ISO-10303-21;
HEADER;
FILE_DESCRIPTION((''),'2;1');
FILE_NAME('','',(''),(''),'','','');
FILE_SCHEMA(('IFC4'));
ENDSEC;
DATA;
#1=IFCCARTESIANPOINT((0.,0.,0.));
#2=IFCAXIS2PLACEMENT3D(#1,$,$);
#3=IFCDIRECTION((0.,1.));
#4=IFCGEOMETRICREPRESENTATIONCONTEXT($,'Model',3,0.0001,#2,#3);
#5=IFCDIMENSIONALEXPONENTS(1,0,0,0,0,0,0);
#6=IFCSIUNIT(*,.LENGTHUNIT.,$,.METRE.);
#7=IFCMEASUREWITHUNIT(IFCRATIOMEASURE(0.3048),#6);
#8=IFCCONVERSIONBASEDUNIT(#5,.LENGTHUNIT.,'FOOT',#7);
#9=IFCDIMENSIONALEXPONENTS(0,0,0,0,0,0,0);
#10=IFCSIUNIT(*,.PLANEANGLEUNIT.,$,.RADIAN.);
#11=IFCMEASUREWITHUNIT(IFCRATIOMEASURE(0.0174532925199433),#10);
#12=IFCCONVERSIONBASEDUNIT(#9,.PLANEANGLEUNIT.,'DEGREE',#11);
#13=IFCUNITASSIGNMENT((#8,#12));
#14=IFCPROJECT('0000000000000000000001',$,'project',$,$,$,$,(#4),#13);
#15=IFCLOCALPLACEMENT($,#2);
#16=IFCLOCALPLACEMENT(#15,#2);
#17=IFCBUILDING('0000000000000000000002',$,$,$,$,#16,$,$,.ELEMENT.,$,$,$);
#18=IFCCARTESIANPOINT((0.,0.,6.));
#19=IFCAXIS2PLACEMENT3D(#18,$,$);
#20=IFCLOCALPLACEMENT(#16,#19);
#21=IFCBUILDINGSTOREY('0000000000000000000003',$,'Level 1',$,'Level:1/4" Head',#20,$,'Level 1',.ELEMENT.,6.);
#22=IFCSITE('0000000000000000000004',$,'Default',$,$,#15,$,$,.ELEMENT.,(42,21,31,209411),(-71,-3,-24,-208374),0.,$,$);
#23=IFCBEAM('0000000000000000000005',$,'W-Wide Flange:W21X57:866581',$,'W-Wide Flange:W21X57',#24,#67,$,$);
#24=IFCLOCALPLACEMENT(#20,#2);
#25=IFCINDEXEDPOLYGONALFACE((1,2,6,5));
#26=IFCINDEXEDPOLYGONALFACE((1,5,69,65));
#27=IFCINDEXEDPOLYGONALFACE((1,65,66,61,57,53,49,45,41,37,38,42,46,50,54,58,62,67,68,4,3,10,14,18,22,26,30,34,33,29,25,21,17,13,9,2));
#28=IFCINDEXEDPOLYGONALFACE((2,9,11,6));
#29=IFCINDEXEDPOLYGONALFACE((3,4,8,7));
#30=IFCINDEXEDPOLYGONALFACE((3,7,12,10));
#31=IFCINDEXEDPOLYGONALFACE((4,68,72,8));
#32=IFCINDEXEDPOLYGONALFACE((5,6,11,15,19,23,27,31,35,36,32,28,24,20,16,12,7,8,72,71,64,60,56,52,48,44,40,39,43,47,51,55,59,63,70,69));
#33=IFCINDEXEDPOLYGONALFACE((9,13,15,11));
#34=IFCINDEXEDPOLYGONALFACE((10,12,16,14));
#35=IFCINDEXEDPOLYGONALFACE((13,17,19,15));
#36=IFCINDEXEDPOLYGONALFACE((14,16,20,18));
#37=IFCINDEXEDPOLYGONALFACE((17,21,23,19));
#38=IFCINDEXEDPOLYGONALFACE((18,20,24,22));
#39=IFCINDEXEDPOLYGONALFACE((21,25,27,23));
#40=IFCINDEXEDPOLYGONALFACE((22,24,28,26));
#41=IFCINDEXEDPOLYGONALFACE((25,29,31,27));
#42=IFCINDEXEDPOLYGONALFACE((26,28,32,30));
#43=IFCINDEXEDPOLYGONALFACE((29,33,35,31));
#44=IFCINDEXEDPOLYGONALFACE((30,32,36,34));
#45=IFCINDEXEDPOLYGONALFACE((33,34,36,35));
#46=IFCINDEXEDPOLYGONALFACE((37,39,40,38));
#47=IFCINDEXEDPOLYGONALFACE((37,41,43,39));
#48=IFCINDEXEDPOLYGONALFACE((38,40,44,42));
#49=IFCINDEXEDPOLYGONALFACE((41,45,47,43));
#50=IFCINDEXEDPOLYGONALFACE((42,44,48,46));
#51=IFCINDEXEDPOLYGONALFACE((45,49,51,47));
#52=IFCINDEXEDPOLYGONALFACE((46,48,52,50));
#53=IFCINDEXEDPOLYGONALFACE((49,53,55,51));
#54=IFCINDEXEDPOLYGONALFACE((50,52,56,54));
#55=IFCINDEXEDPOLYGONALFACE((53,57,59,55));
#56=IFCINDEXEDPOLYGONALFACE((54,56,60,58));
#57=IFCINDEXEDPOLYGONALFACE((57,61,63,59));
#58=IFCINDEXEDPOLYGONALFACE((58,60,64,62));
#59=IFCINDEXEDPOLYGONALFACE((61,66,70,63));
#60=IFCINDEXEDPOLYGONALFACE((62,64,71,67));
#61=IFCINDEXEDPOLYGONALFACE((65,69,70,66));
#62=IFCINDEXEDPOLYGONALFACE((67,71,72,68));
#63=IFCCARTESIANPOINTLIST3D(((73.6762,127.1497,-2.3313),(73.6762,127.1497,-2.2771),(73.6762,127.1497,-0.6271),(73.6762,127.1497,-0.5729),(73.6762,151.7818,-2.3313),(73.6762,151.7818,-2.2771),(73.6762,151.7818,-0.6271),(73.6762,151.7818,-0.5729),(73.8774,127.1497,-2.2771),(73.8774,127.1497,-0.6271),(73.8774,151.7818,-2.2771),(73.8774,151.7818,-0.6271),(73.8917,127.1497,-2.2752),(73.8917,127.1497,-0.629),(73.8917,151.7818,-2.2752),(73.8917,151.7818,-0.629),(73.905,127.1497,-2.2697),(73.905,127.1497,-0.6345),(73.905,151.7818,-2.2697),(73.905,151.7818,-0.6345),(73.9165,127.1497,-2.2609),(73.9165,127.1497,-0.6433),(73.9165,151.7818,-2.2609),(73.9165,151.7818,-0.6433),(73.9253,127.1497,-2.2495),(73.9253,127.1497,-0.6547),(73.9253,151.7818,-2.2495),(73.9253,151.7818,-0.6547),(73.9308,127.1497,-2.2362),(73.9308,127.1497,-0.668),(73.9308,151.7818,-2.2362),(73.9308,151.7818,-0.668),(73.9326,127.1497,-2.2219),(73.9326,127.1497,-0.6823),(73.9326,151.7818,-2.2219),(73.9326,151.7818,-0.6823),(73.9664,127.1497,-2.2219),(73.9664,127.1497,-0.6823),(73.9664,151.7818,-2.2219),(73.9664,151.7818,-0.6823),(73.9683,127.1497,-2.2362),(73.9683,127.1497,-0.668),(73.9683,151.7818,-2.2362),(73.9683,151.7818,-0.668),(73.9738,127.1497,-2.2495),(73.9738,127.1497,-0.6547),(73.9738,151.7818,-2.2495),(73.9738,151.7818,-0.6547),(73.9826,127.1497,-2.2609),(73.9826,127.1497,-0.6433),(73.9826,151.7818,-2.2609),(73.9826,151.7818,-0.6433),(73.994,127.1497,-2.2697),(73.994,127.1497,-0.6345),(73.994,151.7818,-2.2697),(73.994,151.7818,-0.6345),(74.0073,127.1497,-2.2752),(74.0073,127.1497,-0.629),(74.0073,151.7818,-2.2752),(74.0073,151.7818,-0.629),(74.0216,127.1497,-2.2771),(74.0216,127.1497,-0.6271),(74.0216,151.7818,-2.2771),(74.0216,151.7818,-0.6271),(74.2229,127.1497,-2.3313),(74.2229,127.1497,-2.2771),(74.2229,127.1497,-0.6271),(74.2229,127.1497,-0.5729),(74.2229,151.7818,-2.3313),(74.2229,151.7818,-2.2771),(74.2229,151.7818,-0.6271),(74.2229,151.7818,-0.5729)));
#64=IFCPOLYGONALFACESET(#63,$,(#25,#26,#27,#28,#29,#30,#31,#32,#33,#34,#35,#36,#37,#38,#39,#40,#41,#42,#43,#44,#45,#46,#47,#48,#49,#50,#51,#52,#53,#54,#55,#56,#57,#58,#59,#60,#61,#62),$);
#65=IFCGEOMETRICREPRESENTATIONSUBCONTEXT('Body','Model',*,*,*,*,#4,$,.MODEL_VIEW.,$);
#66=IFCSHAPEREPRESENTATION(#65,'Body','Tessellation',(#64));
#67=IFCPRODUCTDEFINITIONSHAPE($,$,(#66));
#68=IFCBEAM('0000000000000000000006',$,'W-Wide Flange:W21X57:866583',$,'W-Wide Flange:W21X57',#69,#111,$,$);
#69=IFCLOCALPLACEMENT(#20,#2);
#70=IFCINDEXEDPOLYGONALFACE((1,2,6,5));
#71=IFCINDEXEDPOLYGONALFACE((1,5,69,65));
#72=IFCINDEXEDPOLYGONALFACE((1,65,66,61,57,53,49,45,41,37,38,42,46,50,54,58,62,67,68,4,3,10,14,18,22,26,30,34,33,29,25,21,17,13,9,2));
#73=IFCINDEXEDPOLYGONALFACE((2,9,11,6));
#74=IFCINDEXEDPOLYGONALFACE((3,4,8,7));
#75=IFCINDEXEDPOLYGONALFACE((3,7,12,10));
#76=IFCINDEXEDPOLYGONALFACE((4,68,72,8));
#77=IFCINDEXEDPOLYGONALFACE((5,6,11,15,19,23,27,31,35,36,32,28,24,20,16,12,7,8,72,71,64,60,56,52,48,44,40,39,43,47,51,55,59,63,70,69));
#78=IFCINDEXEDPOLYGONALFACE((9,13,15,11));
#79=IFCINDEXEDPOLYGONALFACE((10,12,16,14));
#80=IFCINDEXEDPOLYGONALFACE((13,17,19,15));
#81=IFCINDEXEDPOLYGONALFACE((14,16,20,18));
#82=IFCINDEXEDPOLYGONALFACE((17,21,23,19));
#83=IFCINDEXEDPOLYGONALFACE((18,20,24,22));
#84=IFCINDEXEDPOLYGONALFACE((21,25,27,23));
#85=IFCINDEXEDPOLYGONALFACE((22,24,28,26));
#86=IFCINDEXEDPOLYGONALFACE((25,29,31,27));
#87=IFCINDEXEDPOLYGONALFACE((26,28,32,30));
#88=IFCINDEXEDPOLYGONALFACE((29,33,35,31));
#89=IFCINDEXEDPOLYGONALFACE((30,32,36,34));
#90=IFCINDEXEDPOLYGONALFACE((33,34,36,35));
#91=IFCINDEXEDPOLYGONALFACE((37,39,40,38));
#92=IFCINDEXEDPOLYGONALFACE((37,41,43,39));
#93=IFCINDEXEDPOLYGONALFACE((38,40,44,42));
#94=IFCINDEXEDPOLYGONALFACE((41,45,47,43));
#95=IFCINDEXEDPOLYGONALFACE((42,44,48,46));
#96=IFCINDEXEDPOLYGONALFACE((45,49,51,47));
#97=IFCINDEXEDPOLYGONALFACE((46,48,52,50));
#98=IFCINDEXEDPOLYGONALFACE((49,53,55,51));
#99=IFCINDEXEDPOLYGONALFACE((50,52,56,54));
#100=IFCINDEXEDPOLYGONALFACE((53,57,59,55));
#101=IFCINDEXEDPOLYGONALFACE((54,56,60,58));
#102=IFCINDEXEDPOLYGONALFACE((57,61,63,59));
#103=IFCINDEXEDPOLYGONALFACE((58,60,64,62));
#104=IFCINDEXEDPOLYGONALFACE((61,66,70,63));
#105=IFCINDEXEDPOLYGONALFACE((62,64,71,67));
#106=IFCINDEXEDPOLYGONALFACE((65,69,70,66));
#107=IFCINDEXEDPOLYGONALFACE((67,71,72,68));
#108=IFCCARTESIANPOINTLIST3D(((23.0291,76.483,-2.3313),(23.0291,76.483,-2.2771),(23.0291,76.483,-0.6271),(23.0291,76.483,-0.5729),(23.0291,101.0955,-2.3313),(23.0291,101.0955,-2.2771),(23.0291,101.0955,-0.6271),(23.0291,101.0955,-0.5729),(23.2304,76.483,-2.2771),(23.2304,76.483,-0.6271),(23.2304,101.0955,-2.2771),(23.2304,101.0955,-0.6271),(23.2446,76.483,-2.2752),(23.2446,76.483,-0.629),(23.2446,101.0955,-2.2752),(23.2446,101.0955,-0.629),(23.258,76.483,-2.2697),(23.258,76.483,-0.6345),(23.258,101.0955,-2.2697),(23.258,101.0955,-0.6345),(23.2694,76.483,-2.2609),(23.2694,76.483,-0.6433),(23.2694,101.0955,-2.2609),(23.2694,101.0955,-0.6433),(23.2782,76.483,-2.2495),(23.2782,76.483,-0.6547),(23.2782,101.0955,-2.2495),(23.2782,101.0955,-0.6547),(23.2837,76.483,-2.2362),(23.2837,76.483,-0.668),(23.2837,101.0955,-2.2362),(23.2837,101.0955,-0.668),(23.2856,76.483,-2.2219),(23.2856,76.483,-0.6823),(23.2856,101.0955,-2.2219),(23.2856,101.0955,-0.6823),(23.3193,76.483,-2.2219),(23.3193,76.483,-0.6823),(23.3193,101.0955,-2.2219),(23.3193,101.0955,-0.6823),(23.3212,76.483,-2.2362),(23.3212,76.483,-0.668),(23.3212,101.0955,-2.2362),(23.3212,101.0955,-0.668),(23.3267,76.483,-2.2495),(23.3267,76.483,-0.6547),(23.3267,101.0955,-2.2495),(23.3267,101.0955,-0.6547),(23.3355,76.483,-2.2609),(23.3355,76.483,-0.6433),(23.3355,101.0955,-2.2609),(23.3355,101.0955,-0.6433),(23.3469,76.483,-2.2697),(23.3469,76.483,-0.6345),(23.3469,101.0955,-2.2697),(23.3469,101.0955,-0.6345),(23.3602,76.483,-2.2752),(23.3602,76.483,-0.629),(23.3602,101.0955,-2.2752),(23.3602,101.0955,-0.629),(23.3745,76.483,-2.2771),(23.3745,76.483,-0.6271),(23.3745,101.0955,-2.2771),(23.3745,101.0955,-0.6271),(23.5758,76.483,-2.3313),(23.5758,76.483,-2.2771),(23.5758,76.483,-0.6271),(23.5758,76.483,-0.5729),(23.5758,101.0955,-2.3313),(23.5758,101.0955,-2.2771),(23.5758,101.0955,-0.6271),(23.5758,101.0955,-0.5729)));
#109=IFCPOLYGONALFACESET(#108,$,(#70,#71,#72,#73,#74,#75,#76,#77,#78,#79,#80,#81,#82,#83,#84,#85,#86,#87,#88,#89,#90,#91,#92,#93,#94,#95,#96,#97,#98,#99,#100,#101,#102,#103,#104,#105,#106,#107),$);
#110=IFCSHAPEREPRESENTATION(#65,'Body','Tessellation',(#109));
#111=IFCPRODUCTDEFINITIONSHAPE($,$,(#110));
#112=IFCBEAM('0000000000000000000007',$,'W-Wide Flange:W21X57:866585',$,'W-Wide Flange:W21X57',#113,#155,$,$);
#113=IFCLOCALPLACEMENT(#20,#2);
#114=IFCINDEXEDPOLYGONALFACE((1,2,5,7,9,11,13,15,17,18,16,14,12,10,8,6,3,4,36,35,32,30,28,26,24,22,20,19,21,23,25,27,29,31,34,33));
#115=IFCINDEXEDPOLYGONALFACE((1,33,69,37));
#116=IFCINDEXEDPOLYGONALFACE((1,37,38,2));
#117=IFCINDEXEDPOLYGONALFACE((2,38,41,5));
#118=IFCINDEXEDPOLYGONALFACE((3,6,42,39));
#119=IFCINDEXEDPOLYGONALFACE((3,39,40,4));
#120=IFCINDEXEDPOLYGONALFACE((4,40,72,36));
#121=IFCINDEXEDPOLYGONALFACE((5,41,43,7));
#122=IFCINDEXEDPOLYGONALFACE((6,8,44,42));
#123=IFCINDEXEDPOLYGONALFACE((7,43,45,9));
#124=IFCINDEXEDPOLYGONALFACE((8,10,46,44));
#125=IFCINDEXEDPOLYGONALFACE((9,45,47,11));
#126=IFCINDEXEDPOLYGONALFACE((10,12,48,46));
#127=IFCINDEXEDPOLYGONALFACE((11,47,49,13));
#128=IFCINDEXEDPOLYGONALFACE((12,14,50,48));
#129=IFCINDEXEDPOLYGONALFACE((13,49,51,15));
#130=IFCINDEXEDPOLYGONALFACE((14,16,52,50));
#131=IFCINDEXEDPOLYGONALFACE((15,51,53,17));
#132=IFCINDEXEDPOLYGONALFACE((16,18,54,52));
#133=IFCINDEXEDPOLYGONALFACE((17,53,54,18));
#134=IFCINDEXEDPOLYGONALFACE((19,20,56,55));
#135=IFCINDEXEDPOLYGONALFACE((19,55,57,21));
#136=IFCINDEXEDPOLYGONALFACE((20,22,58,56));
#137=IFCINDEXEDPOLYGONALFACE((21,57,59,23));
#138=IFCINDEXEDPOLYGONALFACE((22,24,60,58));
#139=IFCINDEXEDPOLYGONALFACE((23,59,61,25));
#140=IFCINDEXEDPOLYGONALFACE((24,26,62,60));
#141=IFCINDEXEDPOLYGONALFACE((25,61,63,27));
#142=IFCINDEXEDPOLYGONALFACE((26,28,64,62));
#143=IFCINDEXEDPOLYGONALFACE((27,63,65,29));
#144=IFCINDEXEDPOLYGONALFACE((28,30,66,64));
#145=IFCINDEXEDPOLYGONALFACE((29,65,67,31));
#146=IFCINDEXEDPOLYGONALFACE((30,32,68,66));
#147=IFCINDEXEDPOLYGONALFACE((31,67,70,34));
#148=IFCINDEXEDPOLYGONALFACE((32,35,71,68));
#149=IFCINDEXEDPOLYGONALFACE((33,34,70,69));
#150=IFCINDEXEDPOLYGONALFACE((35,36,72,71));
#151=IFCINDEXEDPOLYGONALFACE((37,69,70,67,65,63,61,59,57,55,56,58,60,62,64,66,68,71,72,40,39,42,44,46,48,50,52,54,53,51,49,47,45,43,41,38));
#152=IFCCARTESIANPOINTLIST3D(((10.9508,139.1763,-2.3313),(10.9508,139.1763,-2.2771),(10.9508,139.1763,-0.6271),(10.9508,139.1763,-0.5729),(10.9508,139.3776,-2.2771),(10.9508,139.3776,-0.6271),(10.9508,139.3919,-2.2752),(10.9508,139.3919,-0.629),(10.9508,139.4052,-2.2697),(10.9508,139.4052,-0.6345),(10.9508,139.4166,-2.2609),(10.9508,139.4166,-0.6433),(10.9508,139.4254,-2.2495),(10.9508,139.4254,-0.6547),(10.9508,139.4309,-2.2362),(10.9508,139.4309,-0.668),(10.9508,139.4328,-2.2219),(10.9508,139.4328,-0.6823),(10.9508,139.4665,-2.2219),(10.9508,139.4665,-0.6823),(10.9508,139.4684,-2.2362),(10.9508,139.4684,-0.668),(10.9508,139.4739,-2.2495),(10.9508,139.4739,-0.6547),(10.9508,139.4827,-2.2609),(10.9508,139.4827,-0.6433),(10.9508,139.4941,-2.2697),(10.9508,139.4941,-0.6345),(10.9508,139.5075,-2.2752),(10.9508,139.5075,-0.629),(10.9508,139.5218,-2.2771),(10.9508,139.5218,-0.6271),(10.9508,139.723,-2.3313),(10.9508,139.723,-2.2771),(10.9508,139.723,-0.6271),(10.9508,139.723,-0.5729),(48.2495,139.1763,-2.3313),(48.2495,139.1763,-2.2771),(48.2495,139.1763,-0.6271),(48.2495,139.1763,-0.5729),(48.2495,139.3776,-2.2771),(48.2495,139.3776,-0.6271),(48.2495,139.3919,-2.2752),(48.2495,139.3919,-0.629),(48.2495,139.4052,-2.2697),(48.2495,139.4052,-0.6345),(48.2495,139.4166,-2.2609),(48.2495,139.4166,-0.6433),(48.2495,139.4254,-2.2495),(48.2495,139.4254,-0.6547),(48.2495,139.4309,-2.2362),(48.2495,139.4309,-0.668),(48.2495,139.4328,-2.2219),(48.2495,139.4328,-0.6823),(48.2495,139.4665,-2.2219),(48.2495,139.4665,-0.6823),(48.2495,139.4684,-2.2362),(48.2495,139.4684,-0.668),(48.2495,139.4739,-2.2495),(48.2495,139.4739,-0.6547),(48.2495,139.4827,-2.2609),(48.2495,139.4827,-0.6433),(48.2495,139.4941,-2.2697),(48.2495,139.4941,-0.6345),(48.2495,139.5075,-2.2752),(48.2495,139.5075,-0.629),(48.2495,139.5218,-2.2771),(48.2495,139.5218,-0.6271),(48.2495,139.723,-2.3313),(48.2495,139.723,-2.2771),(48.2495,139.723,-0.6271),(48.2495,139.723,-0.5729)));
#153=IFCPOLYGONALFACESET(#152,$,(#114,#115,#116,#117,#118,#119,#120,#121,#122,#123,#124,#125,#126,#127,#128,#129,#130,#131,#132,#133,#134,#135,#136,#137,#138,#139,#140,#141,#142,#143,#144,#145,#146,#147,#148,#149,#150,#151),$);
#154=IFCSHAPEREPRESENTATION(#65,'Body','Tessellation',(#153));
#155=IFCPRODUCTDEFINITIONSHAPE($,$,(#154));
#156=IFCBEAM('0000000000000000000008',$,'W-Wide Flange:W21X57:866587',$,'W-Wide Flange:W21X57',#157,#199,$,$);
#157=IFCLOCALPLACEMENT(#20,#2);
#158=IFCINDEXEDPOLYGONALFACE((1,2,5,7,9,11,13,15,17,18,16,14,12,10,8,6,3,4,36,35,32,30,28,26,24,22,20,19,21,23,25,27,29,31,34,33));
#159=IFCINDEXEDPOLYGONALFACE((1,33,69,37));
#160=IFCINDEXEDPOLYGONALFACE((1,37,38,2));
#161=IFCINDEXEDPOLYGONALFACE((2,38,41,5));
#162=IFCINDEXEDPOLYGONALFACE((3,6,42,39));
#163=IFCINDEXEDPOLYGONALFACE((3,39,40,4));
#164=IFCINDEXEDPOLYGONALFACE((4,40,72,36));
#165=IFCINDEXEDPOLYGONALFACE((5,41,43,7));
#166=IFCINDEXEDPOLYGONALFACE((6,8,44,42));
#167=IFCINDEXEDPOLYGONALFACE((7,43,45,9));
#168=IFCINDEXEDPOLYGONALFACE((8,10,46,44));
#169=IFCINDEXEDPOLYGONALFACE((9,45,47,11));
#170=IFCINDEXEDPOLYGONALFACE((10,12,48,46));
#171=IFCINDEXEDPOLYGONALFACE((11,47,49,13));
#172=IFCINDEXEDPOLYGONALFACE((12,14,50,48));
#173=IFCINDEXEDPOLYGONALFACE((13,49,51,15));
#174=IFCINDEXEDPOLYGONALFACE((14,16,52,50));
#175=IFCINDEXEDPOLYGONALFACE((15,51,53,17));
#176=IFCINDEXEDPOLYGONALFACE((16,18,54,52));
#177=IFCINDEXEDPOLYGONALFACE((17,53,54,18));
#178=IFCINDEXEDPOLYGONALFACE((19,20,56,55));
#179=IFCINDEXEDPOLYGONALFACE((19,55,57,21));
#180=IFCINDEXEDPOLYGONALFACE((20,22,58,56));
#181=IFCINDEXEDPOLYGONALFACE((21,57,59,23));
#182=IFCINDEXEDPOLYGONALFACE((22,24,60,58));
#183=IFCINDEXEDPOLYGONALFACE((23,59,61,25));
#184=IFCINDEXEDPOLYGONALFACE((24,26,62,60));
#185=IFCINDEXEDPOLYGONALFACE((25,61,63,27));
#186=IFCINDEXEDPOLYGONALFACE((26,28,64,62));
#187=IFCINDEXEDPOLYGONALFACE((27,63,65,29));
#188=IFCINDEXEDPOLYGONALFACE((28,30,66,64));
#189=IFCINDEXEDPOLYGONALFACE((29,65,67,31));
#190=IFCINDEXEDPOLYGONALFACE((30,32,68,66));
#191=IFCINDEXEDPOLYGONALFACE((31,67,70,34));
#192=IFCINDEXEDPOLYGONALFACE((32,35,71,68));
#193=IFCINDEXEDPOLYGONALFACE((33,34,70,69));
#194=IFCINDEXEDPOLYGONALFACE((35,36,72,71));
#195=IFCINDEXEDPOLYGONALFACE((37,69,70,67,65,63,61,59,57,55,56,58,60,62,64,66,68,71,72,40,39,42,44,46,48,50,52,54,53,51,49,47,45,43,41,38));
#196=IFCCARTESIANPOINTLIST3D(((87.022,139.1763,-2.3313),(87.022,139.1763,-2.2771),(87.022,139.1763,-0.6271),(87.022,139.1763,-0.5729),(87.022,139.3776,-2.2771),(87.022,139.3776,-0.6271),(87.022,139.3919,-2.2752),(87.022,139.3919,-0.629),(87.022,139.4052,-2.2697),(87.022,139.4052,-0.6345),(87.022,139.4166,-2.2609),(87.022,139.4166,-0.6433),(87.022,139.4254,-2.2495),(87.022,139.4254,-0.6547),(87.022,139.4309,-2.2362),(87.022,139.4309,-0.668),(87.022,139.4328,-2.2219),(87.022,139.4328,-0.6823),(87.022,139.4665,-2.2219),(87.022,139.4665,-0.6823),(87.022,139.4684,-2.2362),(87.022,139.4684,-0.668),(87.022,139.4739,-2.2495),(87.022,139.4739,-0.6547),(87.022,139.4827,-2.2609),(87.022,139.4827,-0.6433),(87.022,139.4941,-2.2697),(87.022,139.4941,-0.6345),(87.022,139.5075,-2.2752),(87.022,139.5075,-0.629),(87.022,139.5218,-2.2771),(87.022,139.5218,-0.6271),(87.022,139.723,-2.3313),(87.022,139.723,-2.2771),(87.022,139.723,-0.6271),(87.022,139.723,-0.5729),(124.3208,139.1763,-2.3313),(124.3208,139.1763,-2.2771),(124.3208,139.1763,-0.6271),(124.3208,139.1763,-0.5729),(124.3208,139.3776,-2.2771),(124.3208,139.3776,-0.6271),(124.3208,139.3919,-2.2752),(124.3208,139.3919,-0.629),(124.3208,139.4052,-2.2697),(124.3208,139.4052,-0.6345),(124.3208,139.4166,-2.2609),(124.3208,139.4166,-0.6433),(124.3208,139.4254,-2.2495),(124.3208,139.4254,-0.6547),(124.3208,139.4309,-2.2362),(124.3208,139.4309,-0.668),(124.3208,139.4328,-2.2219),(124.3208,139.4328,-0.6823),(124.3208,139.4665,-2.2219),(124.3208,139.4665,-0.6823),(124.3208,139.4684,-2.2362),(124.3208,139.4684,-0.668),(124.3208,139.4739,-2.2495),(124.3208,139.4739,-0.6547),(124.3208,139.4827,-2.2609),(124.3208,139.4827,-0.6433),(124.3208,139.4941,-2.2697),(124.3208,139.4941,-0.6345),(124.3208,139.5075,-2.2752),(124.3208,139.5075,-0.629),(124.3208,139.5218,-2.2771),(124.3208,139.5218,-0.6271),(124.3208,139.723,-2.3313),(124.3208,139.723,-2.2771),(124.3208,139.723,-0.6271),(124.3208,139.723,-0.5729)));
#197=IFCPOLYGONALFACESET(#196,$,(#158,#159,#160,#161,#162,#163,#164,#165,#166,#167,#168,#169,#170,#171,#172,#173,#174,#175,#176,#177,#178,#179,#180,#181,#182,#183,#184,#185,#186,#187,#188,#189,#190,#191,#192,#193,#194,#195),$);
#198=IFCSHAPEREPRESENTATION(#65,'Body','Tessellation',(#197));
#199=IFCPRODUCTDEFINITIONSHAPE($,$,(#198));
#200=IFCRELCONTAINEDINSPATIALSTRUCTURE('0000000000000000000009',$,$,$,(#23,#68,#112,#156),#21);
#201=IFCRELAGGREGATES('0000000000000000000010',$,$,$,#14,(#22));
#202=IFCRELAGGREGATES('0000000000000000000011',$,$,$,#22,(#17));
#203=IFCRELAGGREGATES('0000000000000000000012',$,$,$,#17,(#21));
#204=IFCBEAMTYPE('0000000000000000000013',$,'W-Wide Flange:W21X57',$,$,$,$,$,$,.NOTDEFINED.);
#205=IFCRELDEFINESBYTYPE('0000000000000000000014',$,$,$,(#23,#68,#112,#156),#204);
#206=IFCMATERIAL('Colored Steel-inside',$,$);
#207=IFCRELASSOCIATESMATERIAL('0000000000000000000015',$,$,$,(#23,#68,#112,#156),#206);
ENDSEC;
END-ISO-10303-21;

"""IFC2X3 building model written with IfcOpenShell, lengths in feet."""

from ifc_helpers import new_model, entity, si_unit, converted_unit, direction, frame, frame_2d, origin, place, context, subcontext, project, spatial, i_section, extrude, material, type_object, element, save


model = new_model("IFC2X3")

# Units and contexts
model_context = context("Model", 3, precision=0.0001, world=origin(), true_north=direction((0.0, 1.0)))
body_context = subcontext(model_context, "Body", "Model", "MODEL_VIEW")
ifc_project = project(units=[converted_unit("LENGTHUNIT", "FOOT", entity("IfcRatioMeasure", 0.3048), si_unit("LENGTHUNIT", "METRE"), dimensions=[1, 0, 0, 0, 0, 0, 0]), converted_unit("PLANEANGLEUNIT", "DEGREE", entity("IfcRatioMeasure", 0.0174532925199433), si_unit("PLANEANGLEUNIT", "RADIAN"), dimensions=[0, 0, 0, 0, 0, 0, 0])], contexts=[model_context])

# Site, building, storey
site_placement = place(None, origin())
site = spatial("IfcSite", under=ifc_project, at=site_placement, Name="Default", CompositionType="ELEMENT", RefLatitude=(42, 21, 31, 209411), RefLongitude=(-71, -3, -24, -208374), RefElevation=0.0)
building_placement = place(site_placement, origin())
building = spatial("IfcBuilding", under=site, at=building_placement, CompositionType="ELEMENT")
storey_placement = place(building_placement, frame((0.0, 0.0, 6.0)))
storey = spatial("IfcBuildingStorey", under=building, at=storey_placement, Name="Level 1", ObjectType="Level:1/4\" Head", LongName="Level 1", CompositionType="ELEMENT", Elevation=6.0)

# Shared definitions
ifc_material_1 = material(Name="Colored Steel-inside")

# Beams
beam_type_1 = type_object("IfcBeamType", Name="W-Wide Flange:W21X57", PredefinedType="NOTDEFINED")
beam_1_placement = place(storey_placement, frame((73.9495, 126.7634, 0.0), z_axis=(0.0, 0.0, 1.0), x_axis=(0.0, 1.0, 0.0)))
element("IfcBeam", 1, at=beam_1_placement, inside=storey, type_object=beam_type_1, material=ifc_material_1, Name="W-Wide Flange:W21X57:866581", ObjectType="W-Wide Flange:W21X57", context=body_context, shape_type="SweptSolid", body=[
    extrude(i_section(OverallWidth=0.5467, OverallDepth=1.7583, WebThickness=0.0337, FlangeThickness=0.0542, FilletRadius=0.0552, at=frame_2d((0.0, 0.0), x_axis=(0.0, 1.0))), frame((0.3862, 0.0, -1.4521), z_axis=(1.0, 0.0, 0.0), x_axis=(0.0, 0.0, -1.0)), (0.0, 0.0, 1.0), 24.6321),
])
beam_2_placement = place(storey_placement, frame((23.3024, 101.4105, 0.0), z_axis=(0.0, 0.0, 1.0), x_axis=(0.0, -1.0, 0.0)))
element("IfcBeam", 2, at=beam_2_placement, inside=storey, type_object=beam_type_1, material=ifc_material_1, Name="W-Wide Flange:W21X57:866583", ObjectType="W-Wide Flange:W21X57", context=body_context, shape_type="SweptSolid", body=[
    extrude(i_section(OverallWidth=0.5467, OverallDepth=1.7583, WebThickness=0.0338, FlangeThickness=0.0542, FilletRadius=0.0552, at=frame_2d((0.0, 0.0), x_axis=(0.0, 1.0))), frame((0.315, 0.0, -1.4521), z_axis=(1.0, 0.0, 0.0), x_axis=(0.0, 0.0, -1.0)), (0.0, 0.0, 1.0), 24.6125),
])
beam_3_placement = place(storey_placement, frame((10.6358, 139.4497, 0.0)))
element("IfcBeam", 3, at=beam_3_placement, inside=storey, type_object=beam_type_1, material=ifc_material_1, Name="W-Wide Flange:W21X57:866585", ObjectType="W-Wide Flange:W21X57", context=body_context, shape_type="SweptSolid", body=[
    extrude(i_section(OverallWidth=0.5467, OverallDepth=1.7583, WebThickness=0.0337, FlangeThickness=0.0542, FilletRadius=0.0552, at=frame_2d((0.0, 0.0), x_axis=(0.0, 1.0))), frame((0.315, 0.0, -1.4521), z_axis=(1.0, 0.0, 0.0), x_axis=(0.0, 0.0, -1.0)), (0.0, 0.0, 1.0), 37.2988),
])
beam_4_placement = place(storey_placement, frame((86.6358, 139.4497, 0.0)))
element("IfcBeam", 4, at=beam_4_placement, inside=storey, type_object=beam_type_1, material=ifc_material_1, Name="W-Wide Flange:W21X57:866587", ObjectType="W-Wide Flange:W21X57", context=body_context, shape_type="SweptSolid", body=[
    extrude(i_section(OverallWidth=0.5467, OverallDepth=1.7583, WebThickness=0.0337, FlangeThickness=0.0542, FilletRadius=0.0552, at=frame_2d((0.0, 0.0), x_axis=(0.0, 1.0))), frame((0.3863, 0.0, -1.4521), z_axis=(1.0, 0.0, 0.0), x_axis=(0.0, 0.0, -1.0)), (0.0, 0.0, 1.0), 37.2987),
])

save(model, "model.ifc")
